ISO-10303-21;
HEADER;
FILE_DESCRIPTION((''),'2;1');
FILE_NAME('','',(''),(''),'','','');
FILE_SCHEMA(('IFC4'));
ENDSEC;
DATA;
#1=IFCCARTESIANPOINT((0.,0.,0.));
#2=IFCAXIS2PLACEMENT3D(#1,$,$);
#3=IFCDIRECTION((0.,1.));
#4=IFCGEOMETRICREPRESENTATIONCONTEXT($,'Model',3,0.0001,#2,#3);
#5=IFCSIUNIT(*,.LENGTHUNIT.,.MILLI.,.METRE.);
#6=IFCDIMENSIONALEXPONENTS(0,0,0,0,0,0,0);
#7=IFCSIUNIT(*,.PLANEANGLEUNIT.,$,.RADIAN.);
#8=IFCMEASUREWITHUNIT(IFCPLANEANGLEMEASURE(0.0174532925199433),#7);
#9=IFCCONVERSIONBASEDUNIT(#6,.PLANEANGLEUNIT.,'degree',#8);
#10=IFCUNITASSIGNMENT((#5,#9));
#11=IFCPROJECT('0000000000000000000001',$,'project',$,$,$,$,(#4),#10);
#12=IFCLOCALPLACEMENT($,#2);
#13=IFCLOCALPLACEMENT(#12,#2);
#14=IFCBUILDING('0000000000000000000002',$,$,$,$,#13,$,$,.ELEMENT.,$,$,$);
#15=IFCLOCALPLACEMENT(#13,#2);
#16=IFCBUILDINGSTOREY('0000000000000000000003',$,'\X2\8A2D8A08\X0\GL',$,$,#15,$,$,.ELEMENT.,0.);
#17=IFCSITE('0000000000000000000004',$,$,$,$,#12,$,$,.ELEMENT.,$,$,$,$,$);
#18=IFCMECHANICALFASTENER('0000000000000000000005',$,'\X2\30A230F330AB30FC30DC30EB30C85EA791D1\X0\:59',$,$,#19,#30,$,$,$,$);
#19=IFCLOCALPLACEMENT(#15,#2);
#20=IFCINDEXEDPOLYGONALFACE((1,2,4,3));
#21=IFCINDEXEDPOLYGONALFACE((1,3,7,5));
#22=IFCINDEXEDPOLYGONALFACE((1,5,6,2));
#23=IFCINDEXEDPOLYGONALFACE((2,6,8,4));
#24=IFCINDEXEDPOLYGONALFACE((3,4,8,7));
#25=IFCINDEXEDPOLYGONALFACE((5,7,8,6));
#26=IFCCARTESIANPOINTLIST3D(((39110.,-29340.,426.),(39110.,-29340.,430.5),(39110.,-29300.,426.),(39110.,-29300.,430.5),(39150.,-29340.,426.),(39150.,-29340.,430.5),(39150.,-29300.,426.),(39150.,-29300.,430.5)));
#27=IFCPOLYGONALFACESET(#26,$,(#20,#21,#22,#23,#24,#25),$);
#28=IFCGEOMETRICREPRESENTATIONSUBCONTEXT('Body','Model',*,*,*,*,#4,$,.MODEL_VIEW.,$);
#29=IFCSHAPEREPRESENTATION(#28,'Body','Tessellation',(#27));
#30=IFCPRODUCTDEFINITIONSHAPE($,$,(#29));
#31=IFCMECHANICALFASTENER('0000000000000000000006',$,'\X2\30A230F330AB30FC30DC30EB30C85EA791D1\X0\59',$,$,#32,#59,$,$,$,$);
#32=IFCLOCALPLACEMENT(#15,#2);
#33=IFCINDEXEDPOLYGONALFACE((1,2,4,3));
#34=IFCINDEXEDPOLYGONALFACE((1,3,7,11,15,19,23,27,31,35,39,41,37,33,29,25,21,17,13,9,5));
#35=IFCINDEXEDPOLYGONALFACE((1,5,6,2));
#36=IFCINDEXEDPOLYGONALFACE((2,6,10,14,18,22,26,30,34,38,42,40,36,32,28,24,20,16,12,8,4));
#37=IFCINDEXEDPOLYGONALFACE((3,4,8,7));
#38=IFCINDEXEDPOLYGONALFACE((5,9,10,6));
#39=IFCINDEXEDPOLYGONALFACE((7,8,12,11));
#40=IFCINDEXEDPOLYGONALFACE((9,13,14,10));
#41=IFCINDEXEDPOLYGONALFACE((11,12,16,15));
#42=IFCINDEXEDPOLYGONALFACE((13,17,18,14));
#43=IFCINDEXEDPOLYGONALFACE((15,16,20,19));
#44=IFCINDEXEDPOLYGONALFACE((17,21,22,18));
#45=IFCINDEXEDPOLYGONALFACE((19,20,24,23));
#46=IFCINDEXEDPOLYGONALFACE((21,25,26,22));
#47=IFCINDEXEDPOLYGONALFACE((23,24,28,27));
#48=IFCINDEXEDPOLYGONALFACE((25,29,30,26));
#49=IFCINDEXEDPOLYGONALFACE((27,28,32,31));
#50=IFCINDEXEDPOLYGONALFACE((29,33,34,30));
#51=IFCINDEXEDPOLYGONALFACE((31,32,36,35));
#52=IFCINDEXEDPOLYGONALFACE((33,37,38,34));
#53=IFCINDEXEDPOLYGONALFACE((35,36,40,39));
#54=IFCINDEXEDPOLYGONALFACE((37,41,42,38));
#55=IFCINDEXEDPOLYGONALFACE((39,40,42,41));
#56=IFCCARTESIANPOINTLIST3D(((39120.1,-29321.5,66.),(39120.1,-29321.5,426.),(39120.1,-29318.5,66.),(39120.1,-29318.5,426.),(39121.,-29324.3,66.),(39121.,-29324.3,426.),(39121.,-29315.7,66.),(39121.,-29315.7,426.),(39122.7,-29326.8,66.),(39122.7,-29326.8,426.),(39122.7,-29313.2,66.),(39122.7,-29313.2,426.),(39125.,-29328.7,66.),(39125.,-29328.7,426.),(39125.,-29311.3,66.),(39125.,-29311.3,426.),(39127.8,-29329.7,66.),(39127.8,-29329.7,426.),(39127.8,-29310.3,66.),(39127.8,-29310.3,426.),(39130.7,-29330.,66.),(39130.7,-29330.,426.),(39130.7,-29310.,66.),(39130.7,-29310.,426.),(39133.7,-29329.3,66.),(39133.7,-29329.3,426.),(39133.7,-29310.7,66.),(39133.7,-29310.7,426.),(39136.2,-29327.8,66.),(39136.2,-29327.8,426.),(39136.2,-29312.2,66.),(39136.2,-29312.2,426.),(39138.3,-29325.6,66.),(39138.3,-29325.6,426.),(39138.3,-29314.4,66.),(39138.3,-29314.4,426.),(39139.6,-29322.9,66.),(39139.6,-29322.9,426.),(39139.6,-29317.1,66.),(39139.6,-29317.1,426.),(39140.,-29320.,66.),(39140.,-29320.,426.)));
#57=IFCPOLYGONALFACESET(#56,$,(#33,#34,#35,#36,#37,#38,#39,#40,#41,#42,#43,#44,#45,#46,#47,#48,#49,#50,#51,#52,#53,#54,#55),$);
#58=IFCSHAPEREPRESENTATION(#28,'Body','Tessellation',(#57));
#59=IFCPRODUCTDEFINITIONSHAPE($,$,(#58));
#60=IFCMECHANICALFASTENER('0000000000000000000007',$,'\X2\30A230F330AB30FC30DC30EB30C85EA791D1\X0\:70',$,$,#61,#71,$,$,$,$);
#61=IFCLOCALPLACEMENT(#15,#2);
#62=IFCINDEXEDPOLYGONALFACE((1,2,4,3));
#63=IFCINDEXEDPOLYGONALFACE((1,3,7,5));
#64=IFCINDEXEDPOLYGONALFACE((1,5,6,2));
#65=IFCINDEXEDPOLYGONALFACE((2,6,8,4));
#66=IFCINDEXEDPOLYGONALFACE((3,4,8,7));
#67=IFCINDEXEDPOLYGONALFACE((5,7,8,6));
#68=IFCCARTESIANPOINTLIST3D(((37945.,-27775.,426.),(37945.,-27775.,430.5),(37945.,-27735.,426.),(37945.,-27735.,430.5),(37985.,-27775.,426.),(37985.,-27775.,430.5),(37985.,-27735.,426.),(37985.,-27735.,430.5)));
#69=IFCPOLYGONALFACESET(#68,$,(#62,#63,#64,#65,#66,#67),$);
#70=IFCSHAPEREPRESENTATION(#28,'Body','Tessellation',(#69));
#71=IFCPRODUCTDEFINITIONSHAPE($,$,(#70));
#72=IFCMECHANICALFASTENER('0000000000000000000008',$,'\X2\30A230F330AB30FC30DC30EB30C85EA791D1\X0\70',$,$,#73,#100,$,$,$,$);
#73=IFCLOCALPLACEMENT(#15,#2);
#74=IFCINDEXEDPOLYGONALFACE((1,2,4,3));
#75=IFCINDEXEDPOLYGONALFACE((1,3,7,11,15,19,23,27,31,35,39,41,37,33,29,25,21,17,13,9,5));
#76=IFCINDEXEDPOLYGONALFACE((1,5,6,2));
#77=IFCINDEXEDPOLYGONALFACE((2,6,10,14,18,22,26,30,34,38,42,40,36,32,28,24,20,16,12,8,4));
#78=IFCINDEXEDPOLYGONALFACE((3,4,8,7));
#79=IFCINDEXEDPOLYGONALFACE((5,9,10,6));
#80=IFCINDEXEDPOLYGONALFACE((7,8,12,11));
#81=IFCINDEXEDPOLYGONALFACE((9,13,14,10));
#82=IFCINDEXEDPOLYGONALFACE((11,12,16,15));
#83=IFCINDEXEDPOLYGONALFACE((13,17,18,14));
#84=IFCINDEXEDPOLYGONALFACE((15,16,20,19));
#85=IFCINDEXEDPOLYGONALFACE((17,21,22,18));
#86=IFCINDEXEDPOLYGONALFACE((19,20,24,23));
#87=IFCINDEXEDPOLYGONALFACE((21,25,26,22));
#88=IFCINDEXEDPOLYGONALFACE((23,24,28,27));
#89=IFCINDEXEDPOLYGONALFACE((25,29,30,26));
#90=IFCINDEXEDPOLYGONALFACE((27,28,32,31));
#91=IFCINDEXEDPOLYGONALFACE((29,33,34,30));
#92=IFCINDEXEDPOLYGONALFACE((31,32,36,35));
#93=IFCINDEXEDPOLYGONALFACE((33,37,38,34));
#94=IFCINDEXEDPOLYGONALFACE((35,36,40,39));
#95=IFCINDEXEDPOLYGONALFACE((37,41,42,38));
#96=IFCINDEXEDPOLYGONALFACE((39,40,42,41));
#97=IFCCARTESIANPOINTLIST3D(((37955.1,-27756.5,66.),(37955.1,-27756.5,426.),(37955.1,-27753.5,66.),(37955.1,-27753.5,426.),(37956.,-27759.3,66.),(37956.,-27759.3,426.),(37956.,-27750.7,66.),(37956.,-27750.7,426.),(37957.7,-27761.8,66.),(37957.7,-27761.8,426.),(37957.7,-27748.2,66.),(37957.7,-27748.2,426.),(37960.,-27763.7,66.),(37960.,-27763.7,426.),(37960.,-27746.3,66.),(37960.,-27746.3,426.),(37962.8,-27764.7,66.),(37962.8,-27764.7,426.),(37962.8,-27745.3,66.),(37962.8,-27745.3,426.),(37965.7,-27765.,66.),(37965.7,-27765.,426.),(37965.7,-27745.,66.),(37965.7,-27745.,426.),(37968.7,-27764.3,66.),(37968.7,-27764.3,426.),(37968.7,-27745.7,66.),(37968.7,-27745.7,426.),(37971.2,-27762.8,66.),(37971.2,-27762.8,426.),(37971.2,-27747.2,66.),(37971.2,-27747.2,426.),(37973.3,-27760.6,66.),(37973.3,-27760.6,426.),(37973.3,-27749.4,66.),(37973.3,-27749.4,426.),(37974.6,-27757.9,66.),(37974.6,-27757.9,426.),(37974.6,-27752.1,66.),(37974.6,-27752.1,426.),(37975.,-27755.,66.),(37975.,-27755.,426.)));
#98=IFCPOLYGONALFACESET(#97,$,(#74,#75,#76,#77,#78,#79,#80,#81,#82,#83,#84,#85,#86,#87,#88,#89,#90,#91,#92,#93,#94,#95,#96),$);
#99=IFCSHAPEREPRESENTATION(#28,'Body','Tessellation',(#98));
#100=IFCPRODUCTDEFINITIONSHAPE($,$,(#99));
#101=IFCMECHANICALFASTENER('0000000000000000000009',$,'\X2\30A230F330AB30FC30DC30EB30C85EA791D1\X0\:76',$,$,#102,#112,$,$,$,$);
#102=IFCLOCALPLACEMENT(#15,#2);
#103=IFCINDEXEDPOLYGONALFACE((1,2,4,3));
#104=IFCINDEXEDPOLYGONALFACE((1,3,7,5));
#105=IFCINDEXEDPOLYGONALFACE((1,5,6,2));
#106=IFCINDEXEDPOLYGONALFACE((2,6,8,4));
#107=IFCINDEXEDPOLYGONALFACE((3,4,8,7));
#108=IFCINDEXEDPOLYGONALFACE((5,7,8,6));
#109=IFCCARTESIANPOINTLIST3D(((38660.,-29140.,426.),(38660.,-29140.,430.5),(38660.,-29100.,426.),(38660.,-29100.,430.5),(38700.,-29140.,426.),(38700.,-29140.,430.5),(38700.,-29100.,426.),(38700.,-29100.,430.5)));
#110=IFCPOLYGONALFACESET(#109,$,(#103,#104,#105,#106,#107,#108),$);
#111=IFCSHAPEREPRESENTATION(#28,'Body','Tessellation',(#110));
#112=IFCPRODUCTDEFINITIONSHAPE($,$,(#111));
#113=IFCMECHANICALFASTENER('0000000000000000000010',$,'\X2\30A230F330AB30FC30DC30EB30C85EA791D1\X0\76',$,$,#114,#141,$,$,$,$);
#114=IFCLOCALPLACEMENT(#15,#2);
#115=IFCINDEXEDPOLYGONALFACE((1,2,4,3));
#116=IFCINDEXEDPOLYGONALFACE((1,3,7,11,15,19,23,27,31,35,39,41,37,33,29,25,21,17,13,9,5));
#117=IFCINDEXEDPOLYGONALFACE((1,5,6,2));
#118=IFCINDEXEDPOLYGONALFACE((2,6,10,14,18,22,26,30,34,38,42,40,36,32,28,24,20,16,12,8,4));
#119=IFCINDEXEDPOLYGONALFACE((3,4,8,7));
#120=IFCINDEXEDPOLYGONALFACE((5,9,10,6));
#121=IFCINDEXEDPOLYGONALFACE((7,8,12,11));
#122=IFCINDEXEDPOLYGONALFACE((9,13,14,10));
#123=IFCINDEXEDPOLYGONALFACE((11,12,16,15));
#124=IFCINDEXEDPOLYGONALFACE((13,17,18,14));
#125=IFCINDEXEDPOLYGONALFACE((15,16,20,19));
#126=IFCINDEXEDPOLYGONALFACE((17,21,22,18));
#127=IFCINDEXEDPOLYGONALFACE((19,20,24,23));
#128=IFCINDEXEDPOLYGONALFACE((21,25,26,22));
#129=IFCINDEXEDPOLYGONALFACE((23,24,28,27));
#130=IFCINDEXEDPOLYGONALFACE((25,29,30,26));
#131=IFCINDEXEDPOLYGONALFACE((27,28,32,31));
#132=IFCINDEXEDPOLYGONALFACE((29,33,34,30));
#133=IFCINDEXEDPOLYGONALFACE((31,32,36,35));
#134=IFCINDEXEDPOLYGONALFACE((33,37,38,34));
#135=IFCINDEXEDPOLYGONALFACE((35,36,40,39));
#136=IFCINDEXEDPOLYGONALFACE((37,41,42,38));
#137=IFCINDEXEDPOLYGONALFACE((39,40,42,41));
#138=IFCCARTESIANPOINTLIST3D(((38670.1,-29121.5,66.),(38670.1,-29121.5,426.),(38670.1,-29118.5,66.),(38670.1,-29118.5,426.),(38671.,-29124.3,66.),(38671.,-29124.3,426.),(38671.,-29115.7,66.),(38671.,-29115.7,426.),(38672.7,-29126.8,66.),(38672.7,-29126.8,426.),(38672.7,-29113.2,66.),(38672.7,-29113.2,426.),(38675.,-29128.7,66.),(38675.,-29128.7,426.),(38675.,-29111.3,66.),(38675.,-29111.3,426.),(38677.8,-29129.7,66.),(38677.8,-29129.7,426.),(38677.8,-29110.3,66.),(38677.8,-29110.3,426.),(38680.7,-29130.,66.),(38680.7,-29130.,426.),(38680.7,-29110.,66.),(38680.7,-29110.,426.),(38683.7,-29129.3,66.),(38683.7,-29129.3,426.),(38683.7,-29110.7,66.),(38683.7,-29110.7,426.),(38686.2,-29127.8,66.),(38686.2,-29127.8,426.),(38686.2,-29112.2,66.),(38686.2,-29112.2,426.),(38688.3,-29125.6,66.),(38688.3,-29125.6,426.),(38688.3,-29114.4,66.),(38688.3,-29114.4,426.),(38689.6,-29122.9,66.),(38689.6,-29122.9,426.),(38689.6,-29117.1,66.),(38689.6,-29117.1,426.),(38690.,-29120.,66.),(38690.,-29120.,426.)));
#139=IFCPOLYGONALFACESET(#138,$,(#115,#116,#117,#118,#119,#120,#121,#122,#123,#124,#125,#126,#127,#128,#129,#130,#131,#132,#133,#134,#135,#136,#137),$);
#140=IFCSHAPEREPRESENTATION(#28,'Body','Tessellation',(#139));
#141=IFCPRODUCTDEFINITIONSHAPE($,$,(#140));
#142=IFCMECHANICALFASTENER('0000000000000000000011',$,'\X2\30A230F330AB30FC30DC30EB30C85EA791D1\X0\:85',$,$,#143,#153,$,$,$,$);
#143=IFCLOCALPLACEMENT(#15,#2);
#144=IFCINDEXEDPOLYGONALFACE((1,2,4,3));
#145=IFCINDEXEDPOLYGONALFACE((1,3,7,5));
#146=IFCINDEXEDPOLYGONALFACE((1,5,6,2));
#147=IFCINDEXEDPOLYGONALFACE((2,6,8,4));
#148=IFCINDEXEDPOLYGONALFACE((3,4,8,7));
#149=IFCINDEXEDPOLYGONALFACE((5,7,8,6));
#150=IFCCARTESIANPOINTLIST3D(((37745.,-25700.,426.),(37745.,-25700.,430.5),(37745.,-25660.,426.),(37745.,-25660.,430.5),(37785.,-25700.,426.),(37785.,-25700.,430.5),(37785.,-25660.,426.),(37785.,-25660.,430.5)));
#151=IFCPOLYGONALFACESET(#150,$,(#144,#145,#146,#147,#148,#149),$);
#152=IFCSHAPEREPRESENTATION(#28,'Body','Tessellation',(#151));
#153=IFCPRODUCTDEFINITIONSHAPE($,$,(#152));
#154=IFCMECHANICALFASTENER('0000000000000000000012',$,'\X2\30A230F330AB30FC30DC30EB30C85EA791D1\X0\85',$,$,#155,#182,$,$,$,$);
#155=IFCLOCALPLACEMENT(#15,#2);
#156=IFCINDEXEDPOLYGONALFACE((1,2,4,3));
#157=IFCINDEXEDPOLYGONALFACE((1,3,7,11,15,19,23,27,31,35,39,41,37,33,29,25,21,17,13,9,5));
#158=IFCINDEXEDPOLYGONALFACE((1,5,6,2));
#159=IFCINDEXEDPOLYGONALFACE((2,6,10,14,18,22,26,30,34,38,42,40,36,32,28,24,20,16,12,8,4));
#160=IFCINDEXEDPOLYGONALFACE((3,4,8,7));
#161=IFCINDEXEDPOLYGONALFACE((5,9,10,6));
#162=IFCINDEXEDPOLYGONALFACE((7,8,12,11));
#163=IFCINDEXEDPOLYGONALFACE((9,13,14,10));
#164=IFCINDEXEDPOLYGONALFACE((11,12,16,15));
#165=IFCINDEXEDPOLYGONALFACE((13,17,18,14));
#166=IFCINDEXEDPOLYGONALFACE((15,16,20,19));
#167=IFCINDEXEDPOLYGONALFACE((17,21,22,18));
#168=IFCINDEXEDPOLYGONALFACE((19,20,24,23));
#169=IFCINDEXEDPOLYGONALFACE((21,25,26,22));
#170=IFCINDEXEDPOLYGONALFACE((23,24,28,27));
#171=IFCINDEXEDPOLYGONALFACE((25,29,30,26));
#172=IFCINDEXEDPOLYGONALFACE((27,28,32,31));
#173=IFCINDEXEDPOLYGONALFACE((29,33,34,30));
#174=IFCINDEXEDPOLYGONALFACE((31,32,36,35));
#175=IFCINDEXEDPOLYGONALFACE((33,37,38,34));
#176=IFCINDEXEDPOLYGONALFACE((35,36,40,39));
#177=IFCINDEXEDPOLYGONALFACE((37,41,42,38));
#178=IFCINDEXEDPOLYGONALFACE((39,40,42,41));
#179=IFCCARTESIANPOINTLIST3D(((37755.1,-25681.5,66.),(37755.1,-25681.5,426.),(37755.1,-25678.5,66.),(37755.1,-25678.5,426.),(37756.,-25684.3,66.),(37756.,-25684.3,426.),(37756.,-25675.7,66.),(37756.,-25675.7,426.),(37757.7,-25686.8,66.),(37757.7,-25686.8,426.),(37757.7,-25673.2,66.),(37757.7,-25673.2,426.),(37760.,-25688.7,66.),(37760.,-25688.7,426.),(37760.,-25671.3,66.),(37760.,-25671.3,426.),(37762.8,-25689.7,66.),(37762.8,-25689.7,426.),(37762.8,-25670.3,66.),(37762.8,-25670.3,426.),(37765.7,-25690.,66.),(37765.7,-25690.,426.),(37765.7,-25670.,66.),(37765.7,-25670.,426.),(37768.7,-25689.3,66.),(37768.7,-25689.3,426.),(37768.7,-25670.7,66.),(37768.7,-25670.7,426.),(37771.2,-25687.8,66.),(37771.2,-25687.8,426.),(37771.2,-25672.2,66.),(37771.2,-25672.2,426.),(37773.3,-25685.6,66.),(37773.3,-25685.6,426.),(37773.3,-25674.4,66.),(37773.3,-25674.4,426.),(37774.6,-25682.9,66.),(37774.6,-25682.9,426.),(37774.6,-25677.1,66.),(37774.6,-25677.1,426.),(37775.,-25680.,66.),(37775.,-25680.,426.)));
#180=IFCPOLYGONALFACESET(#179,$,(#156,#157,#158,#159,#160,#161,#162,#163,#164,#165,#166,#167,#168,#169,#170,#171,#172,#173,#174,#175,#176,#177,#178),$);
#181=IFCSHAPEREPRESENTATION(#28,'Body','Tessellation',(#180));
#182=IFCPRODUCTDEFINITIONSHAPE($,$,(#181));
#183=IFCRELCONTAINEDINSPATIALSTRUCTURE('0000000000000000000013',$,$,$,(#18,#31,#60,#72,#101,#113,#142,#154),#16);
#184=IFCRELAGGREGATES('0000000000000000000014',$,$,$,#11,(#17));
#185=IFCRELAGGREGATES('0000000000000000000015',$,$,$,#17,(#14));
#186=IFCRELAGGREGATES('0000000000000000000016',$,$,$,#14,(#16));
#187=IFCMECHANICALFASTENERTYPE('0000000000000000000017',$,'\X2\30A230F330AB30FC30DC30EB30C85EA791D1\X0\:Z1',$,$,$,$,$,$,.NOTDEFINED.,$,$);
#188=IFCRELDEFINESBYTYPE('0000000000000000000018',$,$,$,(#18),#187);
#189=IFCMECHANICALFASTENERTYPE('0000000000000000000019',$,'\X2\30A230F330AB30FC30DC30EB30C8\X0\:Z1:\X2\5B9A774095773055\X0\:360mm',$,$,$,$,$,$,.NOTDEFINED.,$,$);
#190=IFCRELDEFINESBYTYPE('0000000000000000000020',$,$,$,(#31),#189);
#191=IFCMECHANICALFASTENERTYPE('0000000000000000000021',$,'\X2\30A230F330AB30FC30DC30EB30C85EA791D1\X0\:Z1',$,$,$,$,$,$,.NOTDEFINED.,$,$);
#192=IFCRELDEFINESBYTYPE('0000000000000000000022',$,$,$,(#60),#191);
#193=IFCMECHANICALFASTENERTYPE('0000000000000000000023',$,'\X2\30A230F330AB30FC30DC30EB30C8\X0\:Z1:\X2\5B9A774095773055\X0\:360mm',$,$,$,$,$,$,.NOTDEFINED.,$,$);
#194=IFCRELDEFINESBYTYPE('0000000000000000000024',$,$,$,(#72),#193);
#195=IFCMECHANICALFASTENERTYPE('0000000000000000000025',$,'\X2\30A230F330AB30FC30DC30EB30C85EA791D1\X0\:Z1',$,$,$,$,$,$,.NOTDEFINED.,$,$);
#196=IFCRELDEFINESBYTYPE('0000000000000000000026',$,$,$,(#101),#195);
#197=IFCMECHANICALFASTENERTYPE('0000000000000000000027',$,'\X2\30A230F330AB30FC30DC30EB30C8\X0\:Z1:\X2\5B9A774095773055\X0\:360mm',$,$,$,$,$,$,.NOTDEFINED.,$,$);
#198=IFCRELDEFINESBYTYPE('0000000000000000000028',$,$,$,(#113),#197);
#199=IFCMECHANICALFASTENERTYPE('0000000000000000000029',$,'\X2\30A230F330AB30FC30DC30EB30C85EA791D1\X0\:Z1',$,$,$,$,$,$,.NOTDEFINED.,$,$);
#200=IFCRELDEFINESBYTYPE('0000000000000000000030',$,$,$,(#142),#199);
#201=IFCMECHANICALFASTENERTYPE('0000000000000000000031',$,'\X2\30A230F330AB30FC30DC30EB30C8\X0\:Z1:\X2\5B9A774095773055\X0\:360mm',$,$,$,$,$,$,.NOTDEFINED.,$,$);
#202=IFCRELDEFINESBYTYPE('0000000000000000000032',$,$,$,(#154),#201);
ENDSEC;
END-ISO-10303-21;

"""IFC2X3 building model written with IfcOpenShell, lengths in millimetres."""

from ifc_helpers import new_model, entity, si_unit, converted_unit, direction, frame, origin, origin_with_axes, origin_2d, place, context, subcontext, project, spatial, rectangle, circle, extrude, type_object, element, save


model = new_model("IFC2X3")

# Units and contexts
model_context = context("Model", 3, precision=0.0001, world=origin(), true_north=direction((0.0, 1.0)))
body_context = subcontext(model_context, "Body", "Model", "MODEL_VIEW")
ifc_project = project(units=[si_unit("LENGTHUNIT", "METRE", prefix="MILLI"), converted_unit("PLANEANGLEUNIT", "degree", entity("IfcPlaneAngleMeasure", 0.0174532925199433), si_unit("PLANEANGLEUNIT", "RADIAN"), dimensions=[0, 0, 0, 0, 0, 0, 0])], contexts=[model_context])

# Site, building, storey
site_placement = place(None, origin())
site = spatial("IfcSite", under=ifc_project, at=site_placement, CompositionType="ELEMENT")
building_placement = place(site_placement, origin())
building = spatial("IfcBuilding", under=site, at=building_placement, CompositionType="ELEMENT")
storey_placement = place(building_placement, origin())
storey = spatial("IfcBuildingStorey", under=building, at=storey_placement, Name="設計GL", CompositionType="ELEMENT", Elevation=0.0)

# Mechanical fasteners
mechanical_fastener_type_1 = type_object("IfcMechanicalFastenerType", Name="アンカーボルト座金:Z1")
mechanical_fastener_1_placement = place(storey_placement, frame((39130.0, -29320.0, 426.0)))
element("IfcMechanicalFastener", 1, at=mechanical_fastener_1_placement, inside=storey, type_object=mechanical_fastener_type_1, Name="アンカーボルト座金:59", context=body_context, shape_type="SweptSolid", body=[
    extrude(rectangle(XDim=40.0, YDim=40.0, at=origin_2d()), origin_with_axes(), (0.0, 0.0, 1.0), 4.5),
])
mechanical_fastener_type_2 = type_object("IfcMechanicalFastenerType", Name="アンカーボルト:Z1:定着長さ:360mm")
mechanical_fastener_2_placement = place(storey_placement, frame((39130.0, -29320.0, 66.0)))
element("IfcMechanicalFastener", 2, at=mechanical_fastener_2_placement, inside=storey, type_object=mechanical_fastener_type_2, Name="アンカーボルト座金59", context=body_context, shape_type="SweptSolid", body=[
    extrude(circle(Radius=10.0, at=origin_2d()), origin_with_axes(), (0.0, 0.0, 1.0), 360.0),
])
mechanical_fastener_type_3 = type_object("IfcMechanicalFastenerType", Name="アンカーボルト座金:Z1")
mechanical_fastener_3_placement = place(storey_placement, frame((37965.0, -27755.0, 426.0)))
element("IfcMechanicalFastener", 3, at=mechanical_fastener_3_placement, inside=storey, type_object=mechanical_fastener_type_3, Name="アンカーボルト座金:70", context=body_context, shape_type="SweptSolid", body=[
    extrude(rectangle(XDim=40.0, YDim=40.0, at=origin_2d()), origin_with_axes(), (0.0, 0.0, 1.0), 4.5),
])
mechanical_fastener_type_4 = type_object("IfcMechanicalFastenerType", Name="アンカーボルト:Z1:定着長さ:360mm")
mechanical_fastener_4_placement = place(storey_placement, frame((37965.0, -27755.0, 66.0)))
element("IfcMechanicalFastener", 4, at=mechanical_fastener_4_placement, inside=storey, type_object=mechanical_fastener_type_4, Name="アンカーボルト座金70", context=body_context, shape_type="SweptSolid", body=[
    extrude(circle(Radius=10.0, at=origin_2d()), origin_with_axes(), (0.0, 0.0, 1.0), 360.0),
])
mechanical_fastener_type_5 = type_object("IfcMechanicalFastenerType", Name="アンカーボルト座金:Z1")
mechanical_fastener_5_placement = place(storey_placement, frame((38680.0, -29120.0, 426.0)))
element("IfcMechanicalFastener", 5, at=mechanical_fastener_5_placement, inside=storey, type_object=mechanical_fastener_type_5, Name="アンカーボルト座金:76", context=body_context, shape_type="SweptSolid", body=[
    extrude(rectangle(XDim=40.0, YDim=40.0, at=origin_2d()), origin_with_axes(), (0.0, 0.0, 1.0), 4.5),
])
mechanical_fastener_type_6 = type_object("IfcMechanicalFastenerType", Name="アンカーボルト:Z1:定着長さ:360mm")
mechanical_fastener_6_placement = place(storey_placement, frame((38680.0, -29120.0, 66.0)))
element("IfcMechanicalFastener", 6, at=mechanical_fastener_6_placement, inside=storey, type_object=mechanical_fastener_type_6, Name="アンカーボルト座金76", context=body_context, shape_type="SweptSolid", body=[
    extrude(circle(Radius=10.0, at=origin_2d()), origin_with_axes(), (0.0, 0.0, 1.0), 360.0),
])
mechanical_fastener_type_7 = type_object("IfcMechanicalFastenerType", Name="アンカーボルト座金:Z1")
mechanical_fastener_7_placement = place(storey_placement, frame((37765.0, -25680.0, 426.0)))
element("IfcMechanicalFastener", 7, at=mechanical_fastener_7_placement, inside=storey, type_object=mechanical_fastener_type_7, Name="アンカーボルト座金:85", context=body_context, shape_type="SweptSolid", body=[
    extrude(rectangle(XDim=40.0, YDim=40.0, at=origin_2d()), origin_with_axes(), (0.0, 0.0, 1.0), 4.5),
])
mechanical_fastener_type_8 = type_object("IfcMechanicalFastenerType", Name="アンカーボルト:Z1:定着長さ:360mm")
mechanical_fastener_8_placement = place(storey_placement, frame((37765.0, -25680.0, 66.0)))
element("IfcMechanicalFastener", 8, at=mechanical_fastener_8_placement, inside=storey, type_object=mechanical_fastener_type_8, Name="アンカーボルト座金85", context=body_context, shape_type="SweptSolid", body=[
    extrude(circle(Radius=10.0, at=origin_2d()), origin_with_axes(), (0.0, 0.0, 1.0), 360.0),
])

save(model, "model.ifc")
